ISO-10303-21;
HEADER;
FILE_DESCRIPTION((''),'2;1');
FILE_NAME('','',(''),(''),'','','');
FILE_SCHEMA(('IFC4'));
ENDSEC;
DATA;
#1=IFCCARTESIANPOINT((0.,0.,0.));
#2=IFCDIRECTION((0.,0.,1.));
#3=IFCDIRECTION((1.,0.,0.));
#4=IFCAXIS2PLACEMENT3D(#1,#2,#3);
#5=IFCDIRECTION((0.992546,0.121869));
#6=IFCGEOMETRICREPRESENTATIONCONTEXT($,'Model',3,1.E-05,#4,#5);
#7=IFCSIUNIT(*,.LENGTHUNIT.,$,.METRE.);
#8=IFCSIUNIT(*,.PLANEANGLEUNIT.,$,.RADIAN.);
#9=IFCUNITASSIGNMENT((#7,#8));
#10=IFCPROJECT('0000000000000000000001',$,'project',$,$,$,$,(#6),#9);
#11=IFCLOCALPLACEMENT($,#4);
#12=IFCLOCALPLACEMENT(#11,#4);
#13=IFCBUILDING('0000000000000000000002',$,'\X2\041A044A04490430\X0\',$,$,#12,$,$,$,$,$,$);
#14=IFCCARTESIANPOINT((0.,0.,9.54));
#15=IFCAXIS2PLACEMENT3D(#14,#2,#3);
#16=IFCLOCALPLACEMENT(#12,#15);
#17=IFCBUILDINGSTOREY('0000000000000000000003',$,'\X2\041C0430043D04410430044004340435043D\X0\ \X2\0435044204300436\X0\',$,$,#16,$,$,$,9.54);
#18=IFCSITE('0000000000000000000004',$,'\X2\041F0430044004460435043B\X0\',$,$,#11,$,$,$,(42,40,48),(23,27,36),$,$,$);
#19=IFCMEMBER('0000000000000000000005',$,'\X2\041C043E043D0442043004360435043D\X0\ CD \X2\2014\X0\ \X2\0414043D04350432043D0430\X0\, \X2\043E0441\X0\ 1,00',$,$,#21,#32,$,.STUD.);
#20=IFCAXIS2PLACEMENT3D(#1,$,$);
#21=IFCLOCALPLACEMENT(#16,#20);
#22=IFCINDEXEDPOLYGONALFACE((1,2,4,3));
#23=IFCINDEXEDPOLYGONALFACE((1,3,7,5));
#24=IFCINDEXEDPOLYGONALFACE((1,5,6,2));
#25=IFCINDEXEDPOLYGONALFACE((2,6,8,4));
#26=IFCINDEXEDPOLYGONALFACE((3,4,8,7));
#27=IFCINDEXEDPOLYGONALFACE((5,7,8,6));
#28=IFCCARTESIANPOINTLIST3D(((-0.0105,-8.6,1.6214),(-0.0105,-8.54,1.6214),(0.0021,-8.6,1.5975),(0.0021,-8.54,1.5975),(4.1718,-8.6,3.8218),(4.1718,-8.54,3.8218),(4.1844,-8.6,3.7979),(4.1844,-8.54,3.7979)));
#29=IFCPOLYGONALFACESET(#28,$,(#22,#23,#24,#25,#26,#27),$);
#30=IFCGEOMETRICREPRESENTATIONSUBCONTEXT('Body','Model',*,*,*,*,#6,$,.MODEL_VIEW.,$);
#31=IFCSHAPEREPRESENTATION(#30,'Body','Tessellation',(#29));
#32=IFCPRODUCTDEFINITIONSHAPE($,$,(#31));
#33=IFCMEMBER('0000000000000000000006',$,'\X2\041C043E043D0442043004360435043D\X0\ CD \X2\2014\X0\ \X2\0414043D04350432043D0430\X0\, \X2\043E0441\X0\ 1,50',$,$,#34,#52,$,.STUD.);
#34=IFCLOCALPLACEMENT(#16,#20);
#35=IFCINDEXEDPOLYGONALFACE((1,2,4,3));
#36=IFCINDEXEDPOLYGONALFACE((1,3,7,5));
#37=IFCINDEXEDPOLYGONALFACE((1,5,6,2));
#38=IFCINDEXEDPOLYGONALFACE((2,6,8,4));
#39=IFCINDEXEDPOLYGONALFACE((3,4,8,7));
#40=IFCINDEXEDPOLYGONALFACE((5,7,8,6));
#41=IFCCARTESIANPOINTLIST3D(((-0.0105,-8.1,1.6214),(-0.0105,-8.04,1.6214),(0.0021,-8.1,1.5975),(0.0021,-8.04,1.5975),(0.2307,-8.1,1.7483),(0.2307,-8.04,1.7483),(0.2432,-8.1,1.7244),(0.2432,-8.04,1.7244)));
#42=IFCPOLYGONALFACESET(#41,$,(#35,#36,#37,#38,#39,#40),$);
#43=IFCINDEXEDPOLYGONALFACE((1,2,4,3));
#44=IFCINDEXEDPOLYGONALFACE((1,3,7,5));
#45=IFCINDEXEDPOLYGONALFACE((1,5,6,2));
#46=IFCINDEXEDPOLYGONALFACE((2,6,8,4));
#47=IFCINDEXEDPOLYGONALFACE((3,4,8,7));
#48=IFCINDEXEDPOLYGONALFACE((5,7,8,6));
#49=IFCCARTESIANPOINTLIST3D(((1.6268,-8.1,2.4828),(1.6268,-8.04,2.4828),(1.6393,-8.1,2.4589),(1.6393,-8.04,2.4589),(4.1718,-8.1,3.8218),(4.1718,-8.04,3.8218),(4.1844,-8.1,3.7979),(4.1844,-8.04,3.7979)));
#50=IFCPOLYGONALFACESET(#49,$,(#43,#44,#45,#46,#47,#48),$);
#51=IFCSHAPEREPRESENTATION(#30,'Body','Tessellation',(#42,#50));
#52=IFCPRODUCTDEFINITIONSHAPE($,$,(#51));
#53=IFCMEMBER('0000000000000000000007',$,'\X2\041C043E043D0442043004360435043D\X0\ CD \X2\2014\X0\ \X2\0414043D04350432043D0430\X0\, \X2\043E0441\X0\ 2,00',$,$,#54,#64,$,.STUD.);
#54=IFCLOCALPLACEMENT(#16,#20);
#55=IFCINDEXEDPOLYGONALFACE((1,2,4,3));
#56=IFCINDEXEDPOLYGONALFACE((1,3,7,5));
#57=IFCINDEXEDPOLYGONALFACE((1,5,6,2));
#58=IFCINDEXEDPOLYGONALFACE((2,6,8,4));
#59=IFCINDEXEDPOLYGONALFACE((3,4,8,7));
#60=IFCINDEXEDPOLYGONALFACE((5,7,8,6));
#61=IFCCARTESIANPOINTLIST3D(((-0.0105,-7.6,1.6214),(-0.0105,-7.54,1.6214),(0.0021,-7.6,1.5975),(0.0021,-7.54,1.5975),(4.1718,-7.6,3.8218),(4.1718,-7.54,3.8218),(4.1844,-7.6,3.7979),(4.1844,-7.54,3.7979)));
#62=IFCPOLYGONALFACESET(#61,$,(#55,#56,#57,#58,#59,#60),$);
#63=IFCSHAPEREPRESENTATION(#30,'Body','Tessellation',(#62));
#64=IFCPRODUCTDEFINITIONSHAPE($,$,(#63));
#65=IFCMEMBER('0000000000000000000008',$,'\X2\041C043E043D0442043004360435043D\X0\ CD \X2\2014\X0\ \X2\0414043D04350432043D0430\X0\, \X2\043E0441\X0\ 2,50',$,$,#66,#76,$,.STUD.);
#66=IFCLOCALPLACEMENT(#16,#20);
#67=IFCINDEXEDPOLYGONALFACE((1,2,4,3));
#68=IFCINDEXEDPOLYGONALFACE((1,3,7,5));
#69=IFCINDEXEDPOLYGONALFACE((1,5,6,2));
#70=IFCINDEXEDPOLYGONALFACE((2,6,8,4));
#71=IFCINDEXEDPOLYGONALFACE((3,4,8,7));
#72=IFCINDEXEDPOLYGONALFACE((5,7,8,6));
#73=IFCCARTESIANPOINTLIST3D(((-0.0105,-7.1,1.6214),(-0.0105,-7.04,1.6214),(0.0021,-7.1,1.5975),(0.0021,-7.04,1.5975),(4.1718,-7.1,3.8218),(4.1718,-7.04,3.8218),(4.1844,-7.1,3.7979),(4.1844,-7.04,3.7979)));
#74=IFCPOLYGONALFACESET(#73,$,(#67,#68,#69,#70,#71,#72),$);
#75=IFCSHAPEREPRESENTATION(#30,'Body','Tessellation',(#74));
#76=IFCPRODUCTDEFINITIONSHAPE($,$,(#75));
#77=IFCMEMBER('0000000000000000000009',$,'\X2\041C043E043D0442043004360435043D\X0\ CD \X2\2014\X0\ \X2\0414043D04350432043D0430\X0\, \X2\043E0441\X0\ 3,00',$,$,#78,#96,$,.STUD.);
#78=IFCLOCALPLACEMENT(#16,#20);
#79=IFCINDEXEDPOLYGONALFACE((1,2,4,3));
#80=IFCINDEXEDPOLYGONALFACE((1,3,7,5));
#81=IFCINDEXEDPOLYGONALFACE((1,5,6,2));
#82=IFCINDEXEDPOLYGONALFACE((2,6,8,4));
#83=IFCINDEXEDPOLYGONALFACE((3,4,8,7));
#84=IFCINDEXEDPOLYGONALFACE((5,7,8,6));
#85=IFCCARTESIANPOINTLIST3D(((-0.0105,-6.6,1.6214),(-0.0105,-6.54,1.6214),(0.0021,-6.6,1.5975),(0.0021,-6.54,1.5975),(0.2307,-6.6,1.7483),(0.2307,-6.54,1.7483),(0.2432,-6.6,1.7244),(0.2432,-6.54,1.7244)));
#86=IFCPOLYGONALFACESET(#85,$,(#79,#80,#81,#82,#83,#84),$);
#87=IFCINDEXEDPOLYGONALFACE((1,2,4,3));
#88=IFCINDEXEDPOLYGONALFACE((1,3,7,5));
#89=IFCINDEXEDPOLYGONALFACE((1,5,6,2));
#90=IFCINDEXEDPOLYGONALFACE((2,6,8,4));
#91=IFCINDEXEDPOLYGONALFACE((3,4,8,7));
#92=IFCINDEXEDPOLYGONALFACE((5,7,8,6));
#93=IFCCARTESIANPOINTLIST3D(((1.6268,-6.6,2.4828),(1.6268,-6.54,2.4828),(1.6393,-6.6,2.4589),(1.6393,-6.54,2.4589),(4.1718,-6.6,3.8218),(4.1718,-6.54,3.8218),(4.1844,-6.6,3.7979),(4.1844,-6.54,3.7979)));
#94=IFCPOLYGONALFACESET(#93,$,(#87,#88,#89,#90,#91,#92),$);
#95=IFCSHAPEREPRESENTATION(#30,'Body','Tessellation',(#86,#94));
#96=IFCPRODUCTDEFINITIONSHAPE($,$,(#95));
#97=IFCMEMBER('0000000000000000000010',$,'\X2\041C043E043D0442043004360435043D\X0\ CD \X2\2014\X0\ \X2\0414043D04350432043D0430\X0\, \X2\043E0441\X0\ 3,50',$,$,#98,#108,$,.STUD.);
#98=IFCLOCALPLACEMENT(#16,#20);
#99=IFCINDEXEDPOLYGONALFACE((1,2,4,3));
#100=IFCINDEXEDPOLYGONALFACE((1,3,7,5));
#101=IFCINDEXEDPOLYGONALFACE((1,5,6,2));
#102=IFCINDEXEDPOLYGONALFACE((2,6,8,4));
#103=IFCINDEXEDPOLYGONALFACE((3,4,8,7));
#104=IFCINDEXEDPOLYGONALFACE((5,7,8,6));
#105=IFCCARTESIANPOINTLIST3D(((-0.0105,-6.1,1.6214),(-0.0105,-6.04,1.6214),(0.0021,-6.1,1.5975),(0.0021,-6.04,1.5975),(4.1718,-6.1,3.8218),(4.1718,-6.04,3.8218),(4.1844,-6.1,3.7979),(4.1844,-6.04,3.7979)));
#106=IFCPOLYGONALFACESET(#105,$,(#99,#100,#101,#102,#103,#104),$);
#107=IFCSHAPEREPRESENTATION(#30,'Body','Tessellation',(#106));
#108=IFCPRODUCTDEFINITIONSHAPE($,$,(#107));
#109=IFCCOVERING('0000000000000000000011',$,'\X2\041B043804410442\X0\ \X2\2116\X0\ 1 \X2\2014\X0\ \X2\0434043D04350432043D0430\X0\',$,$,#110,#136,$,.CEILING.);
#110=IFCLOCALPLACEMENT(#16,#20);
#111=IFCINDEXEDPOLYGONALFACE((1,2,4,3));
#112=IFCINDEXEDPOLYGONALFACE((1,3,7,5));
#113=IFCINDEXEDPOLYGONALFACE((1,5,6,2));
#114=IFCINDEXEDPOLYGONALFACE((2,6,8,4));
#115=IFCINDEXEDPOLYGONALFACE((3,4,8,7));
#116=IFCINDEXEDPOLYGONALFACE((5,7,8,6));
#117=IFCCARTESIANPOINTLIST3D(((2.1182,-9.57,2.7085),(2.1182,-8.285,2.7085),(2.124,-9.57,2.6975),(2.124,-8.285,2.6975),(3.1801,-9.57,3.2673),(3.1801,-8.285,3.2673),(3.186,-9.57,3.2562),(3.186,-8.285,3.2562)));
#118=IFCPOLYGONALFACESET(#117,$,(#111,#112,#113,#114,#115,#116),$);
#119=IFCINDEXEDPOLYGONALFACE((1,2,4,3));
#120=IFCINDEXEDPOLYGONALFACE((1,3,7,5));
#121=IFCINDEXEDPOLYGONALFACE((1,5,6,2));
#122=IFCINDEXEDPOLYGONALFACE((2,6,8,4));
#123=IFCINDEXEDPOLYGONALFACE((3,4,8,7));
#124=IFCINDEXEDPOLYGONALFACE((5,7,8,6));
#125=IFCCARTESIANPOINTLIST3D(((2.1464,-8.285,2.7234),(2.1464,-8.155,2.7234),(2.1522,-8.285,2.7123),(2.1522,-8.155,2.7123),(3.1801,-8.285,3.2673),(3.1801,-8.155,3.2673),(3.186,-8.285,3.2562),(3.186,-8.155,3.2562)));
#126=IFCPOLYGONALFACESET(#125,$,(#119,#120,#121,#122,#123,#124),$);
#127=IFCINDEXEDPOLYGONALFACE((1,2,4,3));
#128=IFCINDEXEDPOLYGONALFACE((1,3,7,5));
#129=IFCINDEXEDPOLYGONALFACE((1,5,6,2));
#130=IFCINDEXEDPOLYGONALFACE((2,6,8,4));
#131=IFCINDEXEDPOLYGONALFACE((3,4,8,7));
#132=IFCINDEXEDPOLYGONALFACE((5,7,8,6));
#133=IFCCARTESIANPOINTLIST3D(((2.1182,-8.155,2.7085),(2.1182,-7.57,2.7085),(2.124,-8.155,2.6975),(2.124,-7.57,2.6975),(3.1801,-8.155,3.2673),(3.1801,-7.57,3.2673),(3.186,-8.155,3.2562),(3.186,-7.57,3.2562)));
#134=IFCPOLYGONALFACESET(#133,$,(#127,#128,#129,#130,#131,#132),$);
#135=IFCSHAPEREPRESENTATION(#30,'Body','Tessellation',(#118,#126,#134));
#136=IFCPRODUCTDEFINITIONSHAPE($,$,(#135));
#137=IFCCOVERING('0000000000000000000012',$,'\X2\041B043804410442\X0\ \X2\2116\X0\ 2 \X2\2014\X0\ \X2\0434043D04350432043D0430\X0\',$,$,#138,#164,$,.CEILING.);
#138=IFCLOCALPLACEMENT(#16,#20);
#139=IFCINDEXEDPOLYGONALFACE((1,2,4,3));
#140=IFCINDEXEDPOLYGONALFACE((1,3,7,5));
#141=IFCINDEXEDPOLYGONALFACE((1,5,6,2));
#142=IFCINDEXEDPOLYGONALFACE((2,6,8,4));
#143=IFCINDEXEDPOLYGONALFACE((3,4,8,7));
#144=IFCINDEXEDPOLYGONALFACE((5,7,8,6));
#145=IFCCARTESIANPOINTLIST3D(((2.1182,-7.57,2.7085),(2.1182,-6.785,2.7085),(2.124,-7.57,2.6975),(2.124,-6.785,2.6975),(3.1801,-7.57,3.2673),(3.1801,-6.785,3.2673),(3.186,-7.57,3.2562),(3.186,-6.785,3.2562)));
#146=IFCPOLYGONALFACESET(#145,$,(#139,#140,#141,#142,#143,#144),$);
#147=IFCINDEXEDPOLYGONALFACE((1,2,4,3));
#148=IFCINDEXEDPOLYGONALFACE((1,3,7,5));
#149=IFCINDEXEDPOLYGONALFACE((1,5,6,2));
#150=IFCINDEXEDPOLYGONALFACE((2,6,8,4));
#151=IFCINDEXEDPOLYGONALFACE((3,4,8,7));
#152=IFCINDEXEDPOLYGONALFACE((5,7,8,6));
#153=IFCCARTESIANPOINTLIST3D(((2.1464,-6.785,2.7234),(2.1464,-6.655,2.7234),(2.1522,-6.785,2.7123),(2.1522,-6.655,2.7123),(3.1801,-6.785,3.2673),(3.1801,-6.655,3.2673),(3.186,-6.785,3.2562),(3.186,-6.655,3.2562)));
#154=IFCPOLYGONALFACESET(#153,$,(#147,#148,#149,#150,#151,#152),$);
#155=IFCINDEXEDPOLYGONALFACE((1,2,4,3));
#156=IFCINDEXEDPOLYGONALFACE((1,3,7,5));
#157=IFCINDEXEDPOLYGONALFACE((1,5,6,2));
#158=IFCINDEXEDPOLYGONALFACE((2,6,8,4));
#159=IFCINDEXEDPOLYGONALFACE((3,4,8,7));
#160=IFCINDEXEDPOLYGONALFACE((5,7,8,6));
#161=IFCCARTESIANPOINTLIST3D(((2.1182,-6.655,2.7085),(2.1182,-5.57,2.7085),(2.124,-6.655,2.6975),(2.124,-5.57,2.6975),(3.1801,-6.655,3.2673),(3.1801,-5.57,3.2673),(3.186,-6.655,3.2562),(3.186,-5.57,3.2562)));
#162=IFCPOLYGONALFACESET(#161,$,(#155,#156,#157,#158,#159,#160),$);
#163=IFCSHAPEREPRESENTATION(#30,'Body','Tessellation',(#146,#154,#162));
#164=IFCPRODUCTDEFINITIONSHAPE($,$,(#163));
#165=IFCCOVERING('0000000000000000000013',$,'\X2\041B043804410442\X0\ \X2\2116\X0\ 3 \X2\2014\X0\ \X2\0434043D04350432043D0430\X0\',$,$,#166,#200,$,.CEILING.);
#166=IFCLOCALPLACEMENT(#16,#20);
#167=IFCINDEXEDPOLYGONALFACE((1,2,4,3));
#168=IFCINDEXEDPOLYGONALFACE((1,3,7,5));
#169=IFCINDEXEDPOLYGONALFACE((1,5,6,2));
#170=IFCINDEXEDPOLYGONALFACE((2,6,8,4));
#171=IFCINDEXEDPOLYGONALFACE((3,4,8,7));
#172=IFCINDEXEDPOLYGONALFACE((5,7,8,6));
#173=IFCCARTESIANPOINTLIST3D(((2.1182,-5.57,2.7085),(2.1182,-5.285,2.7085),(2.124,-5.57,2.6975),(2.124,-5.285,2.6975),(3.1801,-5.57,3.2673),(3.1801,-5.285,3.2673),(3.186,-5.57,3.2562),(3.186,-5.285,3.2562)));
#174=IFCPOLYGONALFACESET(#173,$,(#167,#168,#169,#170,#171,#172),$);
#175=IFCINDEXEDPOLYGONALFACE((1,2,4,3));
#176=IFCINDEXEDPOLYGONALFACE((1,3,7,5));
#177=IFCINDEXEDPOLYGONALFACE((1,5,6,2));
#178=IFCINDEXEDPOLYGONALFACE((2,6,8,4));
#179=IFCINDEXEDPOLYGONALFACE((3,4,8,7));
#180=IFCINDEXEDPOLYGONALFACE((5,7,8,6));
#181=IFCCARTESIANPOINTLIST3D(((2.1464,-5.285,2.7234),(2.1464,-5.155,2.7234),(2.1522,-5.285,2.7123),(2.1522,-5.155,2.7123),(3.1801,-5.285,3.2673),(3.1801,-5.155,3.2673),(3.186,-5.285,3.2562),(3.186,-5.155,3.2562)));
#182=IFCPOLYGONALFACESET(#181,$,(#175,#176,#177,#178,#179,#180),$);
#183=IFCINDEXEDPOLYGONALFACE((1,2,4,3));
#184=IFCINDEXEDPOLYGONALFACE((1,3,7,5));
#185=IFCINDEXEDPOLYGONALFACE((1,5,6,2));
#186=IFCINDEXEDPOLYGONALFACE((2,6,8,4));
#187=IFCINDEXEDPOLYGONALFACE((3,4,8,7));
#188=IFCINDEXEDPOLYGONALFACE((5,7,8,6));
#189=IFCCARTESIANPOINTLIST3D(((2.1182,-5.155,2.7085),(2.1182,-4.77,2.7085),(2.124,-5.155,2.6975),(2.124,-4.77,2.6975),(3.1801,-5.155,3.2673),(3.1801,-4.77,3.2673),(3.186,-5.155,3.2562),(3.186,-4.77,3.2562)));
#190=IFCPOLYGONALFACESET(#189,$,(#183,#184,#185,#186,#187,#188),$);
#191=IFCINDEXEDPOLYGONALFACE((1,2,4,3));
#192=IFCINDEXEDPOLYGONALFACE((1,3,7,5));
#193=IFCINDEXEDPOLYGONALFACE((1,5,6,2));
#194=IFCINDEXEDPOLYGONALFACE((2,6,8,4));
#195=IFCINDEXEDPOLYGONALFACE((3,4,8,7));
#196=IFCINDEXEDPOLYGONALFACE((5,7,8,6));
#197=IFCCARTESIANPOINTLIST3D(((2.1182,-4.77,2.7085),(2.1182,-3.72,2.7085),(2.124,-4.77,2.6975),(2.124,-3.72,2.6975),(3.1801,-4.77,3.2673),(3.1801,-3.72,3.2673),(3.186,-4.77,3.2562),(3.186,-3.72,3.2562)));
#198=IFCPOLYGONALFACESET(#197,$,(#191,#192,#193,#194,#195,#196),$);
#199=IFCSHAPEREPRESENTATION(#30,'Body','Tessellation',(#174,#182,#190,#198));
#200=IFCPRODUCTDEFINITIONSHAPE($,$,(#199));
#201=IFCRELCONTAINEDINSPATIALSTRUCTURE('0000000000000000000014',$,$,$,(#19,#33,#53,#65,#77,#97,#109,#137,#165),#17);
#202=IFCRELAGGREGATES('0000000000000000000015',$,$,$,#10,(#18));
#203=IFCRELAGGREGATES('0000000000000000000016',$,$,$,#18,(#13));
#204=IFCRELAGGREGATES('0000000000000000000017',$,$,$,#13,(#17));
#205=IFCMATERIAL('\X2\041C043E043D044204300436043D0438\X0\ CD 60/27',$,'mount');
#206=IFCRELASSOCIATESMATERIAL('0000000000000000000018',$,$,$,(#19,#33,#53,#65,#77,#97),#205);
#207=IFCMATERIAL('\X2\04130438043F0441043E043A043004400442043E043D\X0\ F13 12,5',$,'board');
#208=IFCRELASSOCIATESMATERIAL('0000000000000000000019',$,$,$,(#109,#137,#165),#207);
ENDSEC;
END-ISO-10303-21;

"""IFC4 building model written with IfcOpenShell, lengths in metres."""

from ifc_helpers import new_model, si_unit, direction, frame, origin_with_axes, place, context, subcontext, project, spatial, polyline, outline, extrude, material, element, save


model = new_model("IFC4")

# Units and contexts
model_context = context("Model", 3, precision=1e-05, world=origin_with_axes(), true_north=direction((0.992546, 0.121869)))
body_context = subcontext(model_context, "Body", "Model", "MODEL_VIEW")
ifc_project = project(units=[si_unit("LENGTHUNIT", "METRE"), si_unit("PLANEANGLEUNIT", "RADIAN")], contexts=[model_context])

# Site, building, storey
site_placement = place(None, origin_with_axes())
site = spatial("IfcSite", under=ifc_project, at=site_placement, Name="Парцел", RefLatitude=(42, 40, 48), RefLongitude=(23, 27, 36))
building_placement = place(site_placement, origin_with_axes())
building = spatial("IfcBuilding", under=site, at=building_placement, Name="Къща")
storey_placement = place(building_placement, frame((0.0, 0.0, 9.54), z_axis=(0.0, 0.0, 1.0), x_axis=(1.0, 0.0, 0.0)))
storey = spatial("IfcBuildingStorey", under=building, at=storey_placement, Name="Мансарден етаж", Elevation=9.54)

# Members
ifc_material_1 = material(Name="Монтажни CD 60/27", Category="mount")
member_1_placement = place(storey_placement, origin_with_axes())
element("IfcMember", 1, at=member_1_placement, inside=storey, material=ifc_material_1, Name="Монтажен CD — Дневна, ос 1,00", PredefinedType="STUD", context=body_context, shape_type="SweptSolid", body=[
    extrude(outline(polyline([(0.0021, -1.5975), (4.1844, -3.7979), (4.1718, -3.8218), (-0.0105, -1.6214), (0.0021, -1.5975)])), frame((0.0, -8.6, 0.0), z_axis=(0.0, 1.0, 0.0), x_axis=(1.0, 0.0, 0.0)), (0.0, 0.0, 1.0), 0.06),
])
member_2_placement = place(storey_placement, origin_with_axes())
element("IfcMember", 2, at=member_2_placement, inside=storey, material=ifc_material_1, Name="Монтажен CD — Дневна, ос 1,50", PredefinedType="STUD", context=body_context, shape_type="SweptSolid", body=[
    extrude(outline(polyline([(0.0021, -1.5975), (0.2432, -1.7244), (0.2307, -1.7483), (-0.0105, -1.6214), (0.0021, -1.5975)])), frame((0.0, -8.1, 0.0), z_axis=(0.0, 1.0, 0.0), x_axis=(1.0, 0.0, 0.0)), (0.0, 0.0, 1.0), 0.06),
    extrude(outline(polyline([(1.6393, -2.4589), (4.1844, -3.7979), (4.1718, -3.8218), (1.6268, -2.4828), (1.6393, -2.4589)])), frame((0.0, -8.1, 0.0), z_axis=(0.0, 1.0, 0.0), x_axis=(1.0, 0.0, 0.0)), (0.0, 0.0, 1.0), 0.06),
])
member_3_placement = place(storey_placement, origin_with_axes())
element("IfcMember", 3, at=member_3_placement, inside=storey, material=ifc_material_1, Name="Монтажен CD — Дневна, ос 2,00", PredefinedType="STUD", context=body_context, shape_type="SweptSolid", body=[
    extrude(outline(polyline([(0.0021, -1.5975), (4.1844, -3.7979), (4.1718, -3.8218), (-0.0105, -1.6214), (0.0021, -1.5975)])), frame((0.0, -7.6, 0.0), z_axis=(0.0, 1.0, 0.0), x_axis=(1.0, 0.0, 0.0)), (0.0, 0.0, 1.0), 0.06),
])
member_4_placement = place(storey_placement, origin_with_axes())
element("IfcMember", 4, at=member_4_placement, inside=storey, material=ifc_material_1, Name="Монтажен CD — Дневна, ос 2,50", PredefinedType="STUD", context=body_context, shape_type="SweptSolid", body=[
    extrude(outline(polyline([(0.0021, -1.5975), (4.1844, -3.7979), (4.1718, -3.8218), (-0.0105, -1.6214), (0.0021, -1.5975)])), frame((0.0, -7.1, 0.0), z_axis=(0.0, 1.0, 0.0), x_axis=(1.0, 0.0, 0.0)), (0.0, 0.0, 1.0), 0.06),
])
member_5_placement = place(storey_placement, origin_with_axes())
element("IfcMember", 5, at=member_5_placement, inside=storey, material=ifc_material_1, Name="Монтажен CD — Дневна, ос 3,00", PredefinedType="STUD", context=body_context, shape_type="SweptSolid", body=[
    extrude(outline(polyline([(0.0021, -1.5975), (0.2432, -1.7244), (0.2307, -1.7483), (-0.0105, -1.6214), (0.0021, -1.5975)])), frame((0.0, -6.6, 0.0), z_axis=(0.0, 1.0, 0.0), x_axis=(1.0, 0.0, 0.0)), (0.0, 0.0, 1.0), 0.06),
    extrude(outline(polyline([(1.6393, -2.4589), (4.1844, -3.7979), (4.1718, -3.8218), (1.6268, -2.4828), (1.6393, -2.4589)])), frame((0.0, -6.6, 0.0), z_axis=(0.0, 1.0, 0.0), x_axis=(1.0, 0.0, 0.0)), (0.0, 0.0, 1.0), 0.06),
])
member_6_placement = place(storey_placement, origin_with_axes())
element("IfcMember", 6, at=member_6_placement, inside=storey, material=ifc_material_1, Name="Монтажен CD — Дневна, ос 3,50", PredefinedType="STUD", context=body_context, shape_type="SweptSolid", body=[
    extrude(outline(polyline([(0.0021, -1.5975), (4.1844, -3.7979), (4.1718, -3.8218), (-0.0105, -1.6214), (0.0021, -1.5975)])), frame((0.0, -6.1, 0.0), z_axis=(0.0, 1.0, 0.0), x_axis=(1.0, 0.0, 0.0)), (0.0, 0.0, 1.0), 0.06),
])

# Coverings
ifc_material_2 = material(Name="Гипсокартон F13 12,5", Category="board")
covering_1_placement = place(storey_placement, origin_with_axes())
element("IfcCovering", 7, at=covering_1_placement, inside=storey, material=ifc_material_2, Name="Лист № 1 — дневна", PredefinedType="CEILING", context=body_context, shape_type="SweptSolid", body=[
    extrude(outline(polyline([(2.124, -2.6975), (3.186, -3.2562), (3.1801, -3.2673), (2.1181, -2.7085), (2.124, -2.6975)])), frame((0.0, -9.57, 0.0), z_axis=(0.0, 1.0, 0.0), x_axis=(1.0, 0.0, 0.0)), (0.0, 0.0, 1.0), 1.285),
    extrude(outline(polyline([(2.1522, -2.7123), (3.186, -3.2562), (3.1801, -3.2673), (2.1464, -2.7234), (2.1522, -2.7123)])), frame((0.0, -8.285, 0.0), z_axis=(0.0, 1.0, 0.0), x_axis=(1.0, 0.0, 0.0)), (0.0, 0.0, 1.0), 0.13),
    extrude(outline(polyline([(2.124, -2.6975), (3.186, -3.2562), (3.1801, -3.2673), (2.1181, -2.7085), (2.124, -2.6975)])), frame((0.0, -8.155, 0.0), z_axis=(0.0, 1.0, 0.0), x_axis=(1.0, 0.0, 0.0)), (0.0, 0.0, 1.0), 0.585),
])
covering_2_placement = place(storey_placement, origin_with_axes())
element("IfcCovering", 8, at=covering_2_placement, inside=storey, material=ifc_material_2, Name="Лист № 2 — дневна", PredefinedType="CEILING", context=body_context, shape_type="SweptSolid", body=[
    extrude(outline(polyline([(2.124, -2.6975), (3.186, -3.2562), (3.1801, -3.2673), (2.1181, -2.7085), (2.124, -2.6975)])), frame((0.0, -7.57, 0.0), z_axis=(0.0, 1.0, 0.0), x_axis=(1.0, 0.0, 0.0)), (0.0, 0.0, 1.0), 0.785),
    extrude(outline(polyline([(2.1522, -2.7123), (3.186, -3.2562), (3.1801, -3.2673), (2.1464, -2.7234), (2.1522, -2.7123)])), frame((0.0, -6.785, 0.0), z_axis=(0.0, 1.0, 0.0), x_axis=(1.0, 0.0, 0.0)), (0.0, 0.0, 1.0), 0.13),
    extrude(outline(polyline([(2.124, -2.6975), (3.186, -3.2562), (3.1801, -3.2673), (2.1181, -2.7085), (2.124, -2.6975)])), frame((0.0, -6.655, 0.0), z_axis=(0.0, 1.0, 0.0), x_axis=(1.0, 0.0, 0.0)), (0.0, 0.0, 1.0), 1.085),
])
covering_3_placement = place(storey_placement, origin_with_axes())
element("IfcCovering", 9, at=covering_3_placement, inside=storey, material=ifc_material_2, Name="Лист № 3 — дневна", PredefinedType="CEILING", context=body_context, shape_type="SweptSolid", body=[
    extrude(outline(polyline([(2.124, -2.6975), (3.186, -3.2562), (3.1801, -3.2673), (2.1181, -2.7085), (2.124, -2.6975)])), frame((0.0, -5.57, 0.0), z_axis=(0.0, 1.0, 0.0), x_axis=(1.0, 0.0, 0.0)), (0.0, 0.0, 1.0), 0.285),
    extrude(outline(polyline([(2.1522, -2.7123), (3.186, -3.2562), (3.1801, -3.2673), (2.1464, -2.7234), (2.1522, -2.7123)])), frame((0.0, -5.285, 0.0), z_axis=(0.0, 1.0, 0.0), x_axis=(1.0, 0.0, 0.0)), (0.0, 0.0, 1.0), 0.13),
    extrude(outline(polyline([(2.124, -2.6975), (3.186, -3.2562), (3.1801, -3.2673), (2.1181, -2.7085), (2.124, -2.6975)])), frame((0.0, -5.155, 0.0), z_axis=(0.0, 1.0, 0.0), x_axis=(1.0, 0.0, 0.0)), (0.0, 0.0, 1.0), 0.385),
    extrude(outline(polyline([(2.124, -2.6975), (3.186, -3.2562), (3.1801, -3.2673), (2.1181, -2.7085), (2.124, -2.6975)])), frame((0.0, -4.77, 0.0), z_axis=(0.0, 1.0, 0.0), x_axis=(1.0, 0.0, 0.0)), (0.0, 0.0, 1.0), 1.05),
])

save(model, "model.ifc")
